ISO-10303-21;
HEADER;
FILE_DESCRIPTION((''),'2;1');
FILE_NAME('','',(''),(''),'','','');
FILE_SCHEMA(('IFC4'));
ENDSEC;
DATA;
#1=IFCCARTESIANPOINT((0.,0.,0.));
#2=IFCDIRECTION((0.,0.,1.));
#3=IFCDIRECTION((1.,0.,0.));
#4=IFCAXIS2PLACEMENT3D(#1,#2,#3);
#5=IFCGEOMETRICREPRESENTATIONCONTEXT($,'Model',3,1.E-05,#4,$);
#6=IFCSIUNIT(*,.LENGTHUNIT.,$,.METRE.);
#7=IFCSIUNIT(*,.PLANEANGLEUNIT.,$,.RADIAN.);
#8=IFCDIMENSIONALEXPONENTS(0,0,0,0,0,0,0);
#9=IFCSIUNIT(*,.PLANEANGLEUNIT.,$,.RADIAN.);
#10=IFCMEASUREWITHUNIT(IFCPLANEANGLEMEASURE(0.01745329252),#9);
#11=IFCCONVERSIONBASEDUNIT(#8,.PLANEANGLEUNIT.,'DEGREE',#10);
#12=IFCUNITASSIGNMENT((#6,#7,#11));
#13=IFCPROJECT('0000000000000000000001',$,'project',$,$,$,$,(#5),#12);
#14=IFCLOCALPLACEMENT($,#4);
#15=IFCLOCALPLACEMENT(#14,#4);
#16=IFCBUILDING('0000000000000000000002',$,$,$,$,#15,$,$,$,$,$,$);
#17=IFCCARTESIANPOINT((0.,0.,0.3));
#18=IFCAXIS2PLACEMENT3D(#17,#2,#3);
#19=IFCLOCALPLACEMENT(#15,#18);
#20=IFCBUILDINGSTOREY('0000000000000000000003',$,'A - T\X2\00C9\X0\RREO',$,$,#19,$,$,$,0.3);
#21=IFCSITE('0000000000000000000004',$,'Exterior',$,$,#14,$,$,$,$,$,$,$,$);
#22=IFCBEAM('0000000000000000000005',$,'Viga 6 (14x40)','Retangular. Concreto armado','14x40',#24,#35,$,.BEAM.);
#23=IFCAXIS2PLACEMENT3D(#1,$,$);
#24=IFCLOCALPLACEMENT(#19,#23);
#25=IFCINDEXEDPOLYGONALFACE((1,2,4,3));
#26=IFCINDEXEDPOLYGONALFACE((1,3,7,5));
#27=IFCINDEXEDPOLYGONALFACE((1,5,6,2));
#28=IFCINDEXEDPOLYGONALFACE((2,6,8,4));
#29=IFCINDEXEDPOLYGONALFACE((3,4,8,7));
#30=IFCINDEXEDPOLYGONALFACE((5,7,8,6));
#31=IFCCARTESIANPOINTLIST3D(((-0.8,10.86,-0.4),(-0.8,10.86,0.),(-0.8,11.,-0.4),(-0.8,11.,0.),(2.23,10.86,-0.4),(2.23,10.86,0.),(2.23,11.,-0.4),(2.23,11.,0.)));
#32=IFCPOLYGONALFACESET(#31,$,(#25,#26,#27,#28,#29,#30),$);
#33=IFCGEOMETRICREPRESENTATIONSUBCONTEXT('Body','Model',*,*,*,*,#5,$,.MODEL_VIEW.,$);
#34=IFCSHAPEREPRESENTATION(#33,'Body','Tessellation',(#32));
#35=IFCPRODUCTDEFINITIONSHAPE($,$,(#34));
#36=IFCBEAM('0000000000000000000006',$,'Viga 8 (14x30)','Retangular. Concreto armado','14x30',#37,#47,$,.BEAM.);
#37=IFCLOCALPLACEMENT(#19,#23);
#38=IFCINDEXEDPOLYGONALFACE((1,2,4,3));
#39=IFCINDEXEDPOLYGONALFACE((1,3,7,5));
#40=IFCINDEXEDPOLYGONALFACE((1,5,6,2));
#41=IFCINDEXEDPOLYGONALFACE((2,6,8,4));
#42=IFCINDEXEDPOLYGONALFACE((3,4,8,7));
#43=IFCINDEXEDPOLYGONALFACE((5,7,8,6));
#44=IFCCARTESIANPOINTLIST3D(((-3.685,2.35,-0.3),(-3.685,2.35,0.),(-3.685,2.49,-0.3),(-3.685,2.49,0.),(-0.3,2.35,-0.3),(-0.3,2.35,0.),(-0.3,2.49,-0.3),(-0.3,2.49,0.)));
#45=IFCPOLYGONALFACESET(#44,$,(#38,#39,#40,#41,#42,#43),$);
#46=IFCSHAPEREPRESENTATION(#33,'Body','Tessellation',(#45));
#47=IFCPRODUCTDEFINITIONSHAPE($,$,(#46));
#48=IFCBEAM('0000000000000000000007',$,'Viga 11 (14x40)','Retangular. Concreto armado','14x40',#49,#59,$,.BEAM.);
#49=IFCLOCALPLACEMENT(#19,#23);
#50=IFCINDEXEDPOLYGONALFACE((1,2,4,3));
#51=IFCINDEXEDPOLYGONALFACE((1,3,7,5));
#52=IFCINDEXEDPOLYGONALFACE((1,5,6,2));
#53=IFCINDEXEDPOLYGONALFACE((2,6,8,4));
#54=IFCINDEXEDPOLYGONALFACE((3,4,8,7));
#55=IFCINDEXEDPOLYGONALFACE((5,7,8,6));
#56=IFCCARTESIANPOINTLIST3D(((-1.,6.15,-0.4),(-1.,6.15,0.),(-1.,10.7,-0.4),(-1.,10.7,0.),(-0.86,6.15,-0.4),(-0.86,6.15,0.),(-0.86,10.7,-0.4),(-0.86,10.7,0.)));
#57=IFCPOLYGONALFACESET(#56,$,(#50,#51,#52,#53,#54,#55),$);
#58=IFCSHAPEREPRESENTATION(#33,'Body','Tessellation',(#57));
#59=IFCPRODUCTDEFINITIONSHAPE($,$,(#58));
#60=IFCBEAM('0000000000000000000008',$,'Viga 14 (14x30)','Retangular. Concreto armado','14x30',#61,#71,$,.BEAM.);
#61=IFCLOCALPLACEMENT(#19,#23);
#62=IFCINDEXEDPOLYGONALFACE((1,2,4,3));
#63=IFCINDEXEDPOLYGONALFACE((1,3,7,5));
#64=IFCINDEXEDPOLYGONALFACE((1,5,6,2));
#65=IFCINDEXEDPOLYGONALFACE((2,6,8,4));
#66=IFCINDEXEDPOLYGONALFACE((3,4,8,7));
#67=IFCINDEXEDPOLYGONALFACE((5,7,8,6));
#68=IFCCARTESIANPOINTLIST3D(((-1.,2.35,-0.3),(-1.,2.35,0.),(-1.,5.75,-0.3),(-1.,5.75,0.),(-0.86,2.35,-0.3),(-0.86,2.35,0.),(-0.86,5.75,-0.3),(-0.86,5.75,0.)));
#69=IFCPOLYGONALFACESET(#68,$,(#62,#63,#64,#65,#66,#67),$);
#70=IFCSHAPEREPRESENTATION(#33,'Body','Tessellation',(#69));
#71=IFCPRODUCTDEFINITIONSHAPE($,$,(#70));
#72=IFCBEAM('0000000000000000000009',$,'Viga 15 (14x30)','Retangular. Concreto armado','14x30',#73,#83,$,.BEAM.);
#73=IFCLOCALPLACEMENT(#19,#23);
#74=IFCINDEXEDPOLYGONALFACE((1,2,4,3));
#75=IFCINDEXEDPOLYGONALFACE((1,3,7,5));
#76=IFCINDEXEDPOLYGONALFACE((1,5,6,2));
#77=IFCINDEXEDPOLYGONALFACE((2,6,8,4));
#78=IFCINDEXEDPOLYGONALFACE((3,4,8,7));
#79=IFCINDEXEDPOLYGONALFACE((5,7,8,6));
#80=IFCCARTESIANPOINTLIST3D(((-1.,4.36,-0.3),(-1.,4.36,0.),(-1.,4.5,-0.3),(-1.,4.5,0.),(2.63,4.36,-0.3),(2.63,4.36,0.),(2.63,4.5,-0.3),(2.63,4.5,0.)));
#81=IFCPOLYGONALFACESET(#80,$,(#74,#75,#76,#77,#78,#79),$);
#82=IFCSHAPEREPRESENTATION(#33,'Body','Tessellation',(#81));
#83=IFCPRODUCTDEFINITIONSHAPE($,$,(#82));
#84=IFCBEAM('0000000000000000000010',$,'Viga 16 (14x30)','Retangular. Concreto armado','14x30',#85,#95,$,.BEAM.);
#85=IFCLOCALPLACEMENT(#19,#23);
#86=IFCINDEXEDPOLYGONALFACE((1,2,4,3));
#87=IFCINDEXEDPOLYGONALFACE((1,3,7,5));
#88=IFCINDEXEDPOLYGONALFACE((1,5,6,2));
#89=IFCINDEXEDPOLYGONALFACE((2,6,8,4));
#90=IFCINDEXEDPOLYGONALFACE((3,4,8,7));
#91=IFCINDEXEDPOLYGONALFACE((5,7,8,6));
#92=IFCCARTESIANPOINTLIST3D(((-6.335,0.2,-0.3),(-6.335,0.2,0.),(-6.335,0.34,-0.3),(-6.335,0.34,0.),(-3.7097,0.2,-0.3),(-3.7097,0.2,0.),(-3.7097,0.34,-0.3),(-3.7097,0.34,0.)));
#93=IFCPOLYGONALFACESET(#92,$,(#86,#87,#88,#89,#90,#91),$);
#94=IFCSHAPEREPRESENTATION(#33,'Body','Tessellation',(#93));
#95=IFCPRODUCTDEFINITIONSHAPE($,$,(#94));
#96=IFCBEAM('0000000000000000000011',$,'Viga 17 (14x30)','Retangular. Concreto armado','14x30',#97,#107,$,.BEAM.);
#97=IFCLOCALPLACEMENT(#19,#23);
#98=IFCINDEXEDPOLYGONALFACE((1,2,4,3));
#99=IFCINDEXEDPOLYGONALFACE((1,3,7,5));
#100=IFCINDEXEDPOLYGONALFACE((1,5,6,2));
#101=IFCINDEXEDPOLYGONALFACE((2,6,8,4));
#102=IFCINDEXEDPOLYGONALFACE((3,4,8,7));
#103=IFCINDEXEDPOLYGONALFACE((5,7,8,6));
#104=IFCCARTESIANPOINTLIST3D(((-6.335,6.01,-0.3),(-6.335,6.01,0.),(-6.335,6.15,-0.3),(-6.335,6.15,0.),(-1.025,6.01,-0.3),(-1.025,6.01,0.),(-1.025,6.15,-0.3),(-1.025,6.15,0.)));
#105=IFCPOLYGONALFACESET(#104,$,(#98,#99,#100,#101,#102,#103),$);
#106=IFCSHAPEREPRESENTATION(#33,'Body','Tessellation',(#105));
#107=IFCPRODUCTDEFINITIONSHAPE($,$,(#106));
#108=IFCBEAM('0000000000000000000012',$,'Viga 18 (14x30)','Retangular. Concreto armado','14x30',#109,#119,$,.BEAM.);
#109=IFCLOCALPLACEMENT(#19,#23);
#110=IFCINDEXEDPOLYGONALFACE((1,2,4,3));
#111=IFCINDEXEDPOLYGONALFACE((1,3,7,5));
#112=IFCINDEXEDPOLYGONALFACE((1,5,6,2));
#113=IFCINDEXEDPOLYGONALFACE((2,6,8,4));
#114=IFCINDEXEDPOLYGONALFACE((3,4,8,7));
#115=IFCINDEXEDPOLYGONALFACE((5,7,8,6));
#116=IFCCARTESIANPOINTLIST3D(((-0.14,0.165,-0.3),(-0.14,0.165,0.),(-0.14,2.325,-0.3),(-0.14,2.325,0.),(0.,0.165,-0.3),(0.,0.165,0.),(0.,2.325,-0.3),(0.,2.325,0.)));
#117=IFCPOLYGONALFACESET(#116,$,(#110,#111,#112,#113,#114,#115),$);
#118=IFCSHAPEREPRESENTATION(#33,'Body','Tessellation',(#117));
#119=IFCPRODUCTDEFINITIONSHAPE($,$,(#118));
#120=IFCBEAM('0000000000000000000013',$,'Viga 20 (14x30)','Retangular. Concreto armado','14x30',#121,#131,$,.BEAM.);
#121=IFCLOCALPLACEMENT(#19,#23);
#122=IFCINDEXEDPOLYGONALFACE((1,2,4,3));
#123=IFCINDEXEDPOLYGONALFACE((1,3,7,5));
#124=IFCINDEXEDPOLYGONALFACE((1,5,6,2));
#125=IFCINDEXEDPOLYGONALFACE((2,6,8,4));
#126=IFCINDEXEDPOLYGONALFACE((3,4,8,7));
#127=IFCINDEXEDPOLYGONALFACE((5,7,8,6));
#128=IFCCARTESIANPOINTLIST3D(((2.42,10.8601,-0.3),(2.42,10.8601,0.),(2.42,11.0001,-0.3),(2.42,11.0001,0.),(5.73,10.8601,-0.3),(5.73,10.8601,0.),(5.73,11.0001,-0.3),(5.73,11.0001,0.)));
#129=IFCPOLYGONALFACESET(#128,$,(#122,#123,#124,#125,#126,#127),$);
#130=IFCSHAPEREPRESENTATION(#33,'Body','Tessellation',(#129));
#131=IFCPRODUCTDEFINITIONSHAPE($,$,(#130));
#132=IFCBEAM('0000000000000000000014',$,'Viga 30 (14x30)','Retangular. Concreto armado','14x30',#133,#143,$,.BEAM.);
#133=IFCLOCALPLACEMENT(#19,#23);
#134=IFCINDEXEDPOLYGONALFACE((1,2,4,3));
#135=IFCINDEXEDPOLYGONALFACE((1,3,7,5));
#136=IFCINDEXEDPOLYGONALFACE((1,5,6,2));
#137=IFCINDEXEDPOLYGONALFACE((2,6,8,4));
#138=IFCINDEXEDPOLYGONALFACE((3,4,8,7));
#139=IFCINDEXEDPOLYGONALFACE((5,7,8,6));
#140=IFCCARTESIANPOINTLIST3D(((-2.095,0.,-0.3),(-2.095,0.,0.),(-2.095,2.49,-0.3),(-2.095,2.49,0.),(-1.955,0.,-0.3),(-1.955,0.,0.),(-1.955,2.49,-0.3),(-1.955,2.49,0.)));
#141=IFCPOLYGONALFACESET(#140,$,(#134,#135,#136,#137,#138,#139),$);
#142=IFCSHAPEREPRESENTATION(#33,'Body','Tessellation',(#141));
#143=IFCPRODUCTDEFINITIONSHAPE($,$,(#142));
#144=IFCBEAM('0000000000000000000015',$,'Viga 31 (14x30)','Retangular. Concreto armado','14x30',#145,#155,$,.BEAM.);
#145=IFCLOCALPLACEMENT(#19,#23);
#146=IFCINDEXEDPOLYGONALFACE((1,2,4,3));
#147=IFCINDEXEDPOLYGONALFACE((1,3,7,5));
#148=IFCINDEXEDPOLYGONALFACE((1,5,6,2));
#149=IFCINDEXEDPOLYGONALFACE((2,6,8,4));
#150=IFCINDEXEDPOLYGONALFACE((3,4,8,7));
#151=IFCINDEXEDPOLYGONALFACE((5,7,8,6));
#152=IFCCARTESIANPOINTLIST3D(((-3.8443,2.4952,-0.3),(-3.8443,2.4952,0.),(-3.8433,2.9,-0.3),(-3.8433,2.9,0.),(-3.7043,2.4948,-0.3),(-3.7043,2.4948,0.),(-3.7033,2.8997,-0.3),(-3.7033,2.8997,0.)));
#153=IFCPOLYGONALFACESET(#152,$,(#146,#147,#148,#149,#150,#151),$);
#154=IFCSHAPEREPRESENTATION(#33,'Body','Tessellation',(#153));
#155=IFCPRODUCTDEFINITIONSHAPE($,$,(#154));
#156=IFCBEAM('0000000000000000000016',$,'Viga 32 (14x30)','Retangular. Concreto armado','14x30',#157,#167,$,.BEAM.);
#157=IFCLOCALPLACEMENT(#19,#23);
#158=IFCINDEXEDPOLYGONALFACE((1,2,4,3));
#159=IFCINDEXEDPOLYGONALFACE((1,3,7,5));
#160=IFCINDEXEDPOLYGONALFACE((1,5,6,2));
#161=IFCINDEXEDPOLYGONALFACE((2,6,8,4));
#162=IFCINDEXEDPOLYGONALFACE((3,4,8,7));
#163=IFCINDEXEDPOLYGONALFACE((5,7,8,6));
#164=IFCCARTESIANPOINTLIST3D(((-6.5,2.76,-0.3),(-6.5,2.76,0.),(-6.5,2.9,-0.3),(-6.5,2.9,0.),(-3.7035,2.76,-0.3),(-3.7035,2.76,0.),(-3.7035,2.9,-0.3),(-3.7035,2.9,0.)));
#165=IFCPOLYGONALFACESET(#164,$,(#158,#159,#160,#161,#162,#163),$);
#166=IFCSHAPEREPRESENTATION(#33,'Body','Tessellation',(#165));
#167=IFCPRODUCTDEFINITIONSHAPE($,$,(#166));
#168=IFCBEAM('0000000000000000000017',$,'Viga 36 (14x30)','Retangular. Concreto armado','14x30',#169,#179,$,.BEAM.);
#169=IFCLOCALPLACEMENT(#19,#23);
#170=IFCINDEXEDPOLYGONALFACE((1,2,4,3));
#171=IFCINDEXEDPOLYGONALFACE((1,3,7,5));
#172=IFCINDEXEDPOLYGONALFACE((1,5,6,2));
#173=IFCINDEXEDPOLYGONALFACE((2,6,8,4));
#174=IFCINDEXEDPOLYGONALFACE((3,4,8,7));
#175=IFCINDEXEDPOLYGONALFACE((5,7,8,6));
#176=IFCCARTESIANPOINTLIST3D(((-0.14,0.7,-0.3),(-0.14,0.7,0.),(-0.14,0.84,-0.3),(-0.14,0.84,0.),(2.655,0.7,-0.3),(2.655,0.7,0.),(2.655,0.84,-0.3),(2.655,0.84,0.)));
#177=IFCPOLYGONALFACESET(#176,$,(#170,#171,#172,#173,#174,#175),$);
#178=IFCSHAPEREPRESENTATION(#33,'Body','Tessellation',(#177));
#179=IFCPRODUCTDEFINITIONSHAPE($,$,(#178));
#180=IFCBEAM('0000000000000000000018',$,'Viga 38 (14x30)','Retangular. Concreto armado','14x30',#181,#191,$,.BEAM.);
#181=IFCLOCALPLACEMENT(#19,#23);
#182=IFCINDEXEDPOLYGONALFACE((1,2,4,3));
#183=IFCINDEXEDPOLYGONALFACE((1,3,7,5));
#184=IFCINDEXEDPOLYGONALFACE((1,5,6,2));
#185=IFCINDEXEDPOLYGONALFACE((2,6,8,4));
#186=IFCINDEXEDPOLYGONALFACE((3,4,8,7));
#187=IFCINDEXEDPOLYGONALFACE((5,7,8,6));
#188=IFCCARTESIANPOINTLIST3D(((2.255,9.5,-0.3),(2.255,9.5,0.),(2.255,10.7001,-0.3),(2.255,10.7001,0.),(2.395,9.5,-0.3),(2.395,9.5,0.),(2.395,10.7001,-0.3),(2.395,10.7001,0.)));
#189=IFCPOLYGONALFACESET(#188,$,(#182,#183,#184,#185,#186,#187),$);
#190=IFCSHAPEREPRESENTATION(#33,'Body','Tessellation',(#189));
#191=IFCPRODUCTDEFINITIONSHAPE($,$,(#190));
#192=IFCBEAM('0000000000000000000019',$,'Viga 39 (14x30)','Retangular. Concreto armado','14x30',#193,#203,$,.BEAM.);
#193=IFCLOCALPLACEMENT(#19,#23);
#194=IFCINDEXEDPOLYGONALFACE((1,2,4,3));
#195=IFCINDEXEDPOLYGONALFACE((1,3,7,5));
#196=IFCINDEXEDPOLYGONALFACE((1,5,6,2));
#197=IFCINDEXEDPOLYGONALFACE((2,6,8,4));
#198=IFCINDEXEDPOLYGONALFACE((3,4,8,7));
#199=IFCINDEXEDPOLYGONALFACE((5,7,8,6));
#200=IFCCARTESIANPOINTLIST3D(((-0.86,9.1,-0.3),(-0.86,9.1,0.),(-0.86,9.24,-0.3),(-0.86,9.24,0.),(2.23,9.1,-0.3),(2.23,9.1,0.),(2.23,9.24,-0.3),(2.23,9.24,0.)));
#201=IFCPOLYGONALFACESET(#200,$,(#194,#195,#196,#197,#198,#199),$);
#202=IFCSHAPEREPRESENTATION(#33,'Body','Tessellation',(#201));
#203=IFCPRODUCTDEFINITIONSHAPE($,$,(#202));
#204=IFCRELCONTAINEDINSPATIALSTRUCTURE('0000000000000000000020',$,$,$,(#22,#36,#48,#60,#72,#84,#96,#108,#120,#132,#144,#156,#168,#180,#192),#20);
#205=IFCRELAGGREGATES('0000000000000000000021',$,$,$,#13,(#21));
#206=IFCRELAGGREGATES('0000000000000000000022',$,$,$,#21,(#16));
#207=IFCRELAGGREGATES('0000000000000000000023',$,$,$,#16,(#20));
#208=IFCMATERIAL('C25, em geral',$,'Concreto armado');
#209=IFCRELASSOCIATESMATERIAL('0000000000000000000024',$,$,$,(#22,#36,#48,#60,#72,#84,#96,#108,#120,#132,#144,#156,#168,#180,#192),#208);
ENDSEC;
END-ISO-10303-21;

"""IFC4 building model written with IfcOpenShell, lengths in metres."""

from ifc_helpers import new_model, entity, si_unit, converted_unit, frame, frame_2d, origin_with_axes, place, context, subcontext, project, spatial, rectangle, extrude, material, element, save


model = new_model("IFC4")

# Units and contexts
model_context = context("Model", 3, precision=1e-05, world=origin_with_axes())
body_context = subcontext(model_context, "Body", "Model", "MODEL_VIEW")
ifc_project = project(units=[si_unit("LENGTHUNIT", "METRE"), si_unit("PLANEANGLEUNIT", "RADIAN"), converted_unit("PLANEANGLEUNIT", "DEGREE", entity("IfcPlaneAngleMeasure", 0.01745329252), si_unit("PLANEANGLEUNIT", "RADIAN"), dimensions=[0, 0, 0, 0, 0, 0, 0])], contexts=[model_context])

# Site, building, storey
site_placement = place(None, origin_with_axes())
site = spatial("IfcSite", under=ifc_project, at=site_placement, Name="Exterior")
building_placement = place(site_placement, origin_with_axes())
building = spatial("IfcBuilding", under=site, at=building_placement)
storey_placement = place(building_placement, frame((0.0, 0.0, 0.3), z_axis=(0.0, 0.0, 1.0), x_axis=(1.0, 0.0, 0.0)))
storey = spatial("IfcBuildingStorey", under=building, at=storey_placement, Name="A - TÉRREO", Elevation=0.3)

# Shared definitions
ifc_material = material(Name="C25, em geral", Category="Concreto armado")

# Beams
beam_1_placement = place(storey_placement, frame((-0.8, 10.93, 0.0), z_axis=(1.0, 0.0, 0.0), x_axis=(0.0, 1.0, 0.0)))
element("IfcBeam", 1, at=beam_1_placement, inside=storey, material=ifc_material, Name="Viga 6 (14x40)", Description="Retangular. Concreto armado", ObjectType="14x40", PredefinedType="BEAM", context=body_context, shape_type="SweptSolid", body=[
    extrude(rectangle(XDim=0.14, YDim=0.4, at=frame_2d((0.0, -0.2), x_axis=(1.0, 0.0))), origin_with_axes(), (0.0, 0.0, 1.0), 3.03),
])
beam_2_placement = place(storey_placement, frame((-0.3, 2.42, 0.0), z_axis=(-1.0, 0.0, 0.0), x_axis=(0.0, -1.0, 0.0)))
element("IfcBeam", 2, at=beam_2_placement, inside=storey, material=ifc_material, Name="Viga 8 (14x30)", Description="Retangular. Concreto armado", ObjectType="14x30", PredefinedType="BEAM", context=body_context, shape_type="SweptSolid", body=[
    extrude(rectangle(XDim=0.14, YDim=0.3, at=frame_2d((0.0, -0.15), x_axis=(1.0, 0.0))), origin_with_axes(), (0.0, 0.0, 1.0), 3.385),
])
beam_3_placement = place(storey_placement, frame((-0.93, 10.7, 0.0), z_axis=(0.0, -1.0, 0.0), x_axis=(1.0, 0.0, 0.0)))
element("IfcBeam", 3, at=beam_3_placement, inside=storey, material=ifc_material, Name="Viga 11 (14x40)", Description="Retangular. Concreto armado", ObjectType="14x40", PredefinedType="BEAM", context=body_context, shape_type="SweptSolid", body=[
    extrude(rectangle(XDim=0.14, YDim=0.4, at=frame_2d((0.0, -0.2), x_axis=(1.0, 0.0))), origin_with_axes(), (0.0, 0.0, 1.0), 4.55),
])
beam_4_placement = place(storey_placement, frame((-0.93, 2.35, 0.0), z_axis=(0.0, 1.0, 0.0), x_axis=(-1.0, 0.0, 0.0)))
element("IfcBeam", 4, at=beam_4_placement, inside=storey, material=ifc_material, Name="Viga 14 (14x30)", Description="Retangular. Concreto armado", ObjectType="14x30", PredefinedType="BEAM", context=body_context, shape_type="SweptSolid", body=[
    extrude(rectangle(XDim=0.14, YDim=0.3, at=frame_2d((0.0, -0.15), x_axis=(1.0, 0.0))), origin_with_axes(), (0.0, 0.0, 1.0), 3.4),
])
beam_5_placement = place(storey_placement, frame((2.63, 4.43, 0.0), z_axis=(-1.0, 0.0, 0.0), x_axis=(0.0, -1.0, 0.0)))
element("IfcBeam", 5, at=beam_5_placement, inside=storey, material=ifc_material, Name="Viga 15 (14x30)", Description="Retangular. Concreto armado", ObjectType="14x30", PredefinedType="BEAM", context=body_context, shape_type="SweptSolid", body=[
    extrude(rectangle(XDim=0.14, YDim=0.3, at=frame_2d((0.0, -0.15), x_axis=(1.0, 0.0))), origin_with_axes(), (0.0, 0.0, 1.0), 3.63),
])
beam_6_placement = place(storey_placement, frame((-6.335, 0.27, 0.0), z_axis=(1.0, 0.0, 0.0), x_axis=(0.0, 1.0, 0.0)))
element("IfcBeam", 6, at=beam_6_placement, inside=storey, material=ifc_material, Name="Viga 16 (14x30)", Description="Retangular. Concreto armado", ObjectType="14x30", PredefinedType="BEAM", context=body_context, shape_type="SweptSolid", body=[
    extrude(rectangle(XDim=0.14, YDim=0.3, at=frame_2d((0.0, -0.15), x_axis=(1.0, 0.0))), origin_with_axes(), (0.0, 0.0, 1.0), 2.6253),
])
beam_7_placement = place(storey_placement, frame((-6.335, 6.08, 0.0), z_axis=(1.0, 0.0, 0.0), x_axis=(0.0, 1.0, 0.0)))
element("IfcBeam", 7, at=beam_7_placement, inside=storey, material=ifc_material, Name="Viga 17 (14x30)", Description="Retangular. Concreto armado", ObjectType="14x30", PredefinedType="BEAM", context=body_context, shape_type="SweptSolid", body=[
    extrude(rectangle(XDim=0.14, YDim=0.3, at=frame_2d((0.0, -0.15), x_axis=(1.0, 0.0))), origin_with_axes(), (0.0, 0.0, 1.0), 5.31),
])
beam_8_placement = place(storey_placement, frame((-0.07, 0.165, 0.0), z_axis=(0.0, 1.0, 0.0), x_axis=(-1.0, 0.0, 0.0)))
element("IfcBeam", 8, at=beam_8_placement, inside=storey, material=ifc_material, Name="Viga 18 (14x30)", Description="Retangular. Concreto armado", ObjectType="14x30", PredefinedType="BEAM", context=body_context, shape_type="SweptSolid", body=[
    extrude(rectangle(XDim=0.14, YDim=0.3, at=frame_2d((0.0, -0.15), x_axis=(1.0, 0.0))), origin_with_axes(), (0.0, 0.0, 1.0), 2.16),
])
beam_9_placement = place(storey_placement, frame((2.42, 10.9301, 0.0), z_axis=(1.0, 0.0, 0.0), x_axis=(0.0, 1.0, 0.0)))
element("IfcBeam", 9, at=beam_9_placement, inside=storey, material=ifc_material, Name="Viga 20 (14x30)", Description="Retangular. Concreto armado", ObjectType="14x30", PredefinedType="BEAM", context=body_context, shape_type="SweptSolid", body=[
    extrude(rectangle(XDim=0.14, YDim=0.3, at=frame_2d((0.0, -0.15), x_axis=(1.0, 0.0))), origin_with_axes(), (0.0, 0.0, 1.0), 3.31),
])
beam_10_placement = place(storey_placement, frame((-2.025, 0.0, 0.0), z_axis=(0.0, 1.0, 0.0), x_axis=(-1.0, 0.0, 0.0)))
element("IfcBeam", 10, at=beam_10_placement, inside=storey, material=ifc_material, Name="Viga 30 (14x30)", Description="Retangular. Concreto armado", ObjectType="14x30", PredefinedType="BEAM", context=body_context, shape_type="SweptSolid", body=[
    extrude(rectangle(XDim=0.14, YDim=0.3, at=frame_2d((0.0, -0.15), x_axis=(1.0, 0.0))), origin_with_axes(), (0.0, 0.0, 1.0), 2.49),
])
beam_11_placement = place(storey_placement, frame((-3.7743, 2.495, 0.0), z_axis=(0.002427, 0.999997, 0.0), x_axis=(-0.999997, 0.002427, 0.0)))
element("IfcBeam", 11, at=beam_11_placement, inside=storey, material=ifc_material, Name="Viga 31 (14x30)", Description="Retangular. Concreto armado", ObjectType="14x30", PredefinedType="BEAM", context=body_context, shape_type="SweptSolid", body=[
    extrude(rectangle(XDim=0.14, YDim=0.3, at=frame_2d((0.0, -0.15), x_axis=(1.0, 0.0))), origin_with_axes(), (0.0, 0.0, 1.0), 0.4048),
])
beam_12_placement = place(storey_placement, frame((-3.7035, 2.83, 0.0), z_axis=(-1.0, 0.0, 0.0), x_axis=(0.0, -1.0, 0.0)))
element("IfcBeam", 12, at=beam_12_placement, inside=storey, material=ifc_material, Name="Viga 32 (14x30)", Description="Retangular. Concreto armado", ObjectType="14x30", PredefinedType="BEAM", context=body_context, shape_type="SweptSolid", body=[
    extrude(rectangle(XDim=0.14, YDim=0.3, at=frame_2d((0.0, -0.15), x_axis=(1.0, 0.0))), origin_with_axes(), (0.0, 0.0, 1.0), 2.7965),
])
beam_13_placement = place(storey_placement, frame((2.655, 0.77, 0.0), z_axis=(-1.0, 0.0, 0.0), x_axis=(0.0, -1.0, 0.0)))
element("IfcBeam", 13, at=beam_13_placement, inside=storey, material=ifc_material, Name="Viga 36 (14x30)", Description="Retangular. Concreto armado", ObjectType="14x30", PredefinedType="BEAM", context=body_context, shape_type="SweptSolid", body=[
    extrude(rectangle(XDim=0.14, YDim=0.3, at=frame_2d((0.0, -0.15), x_axis=(1.0, 0.0))), origin_with_axes(), (0.0, 0.0, 1.0), 2.795),
])
beam_14_placement = place(storey_placement, frame((2.325, 10.7001, 0.0), z_axis=(0.0, -1.0, 0.0), x_axis=(1.0, 0.0, 0.0)))
element("IfcBeam", 14, at=beam_14_placement, inside=storey, material=ifc_material, Name="Viga 38 (14x30)", Description="Retangular. Concreto armado", ObjectType="14x30", PredefinedType="BEAM", context=body_context, shape_type="SweptSolid", body=[
    extrude(rectangle(XDim=0.14, YDim=0.3, at=frame_2d((0.0, -0.15), x_axis=(1.0, 0.0))), origin_with_axes(), (0.0, 0.0, 1.0), 1.2001),
])
beam_15_placement = place(storey_placement, frame((2.23, 9.17, 0.0), z_axis=(-1.0, 0.0, 0.0), x_axis=(0.0, -1.0, 0.0)))
element("IfcBeam", 15, at=beam_15_placement, inside=storey, material=ifc_material, Name="Viga 39 (14x30)", Description="Retangular. Concreto armado", ObjectType="14x30", PredefinedType="BEAM", context=body_context, shape_type="SweptSolid", body=[
    extrude(rectangle(XDim=0.14, YDim=0.3, at=frame_2d((0.0, -0.15), x_axis=(1.0, 0.0))), origin_with_axes(), (0.0, 0.0, 1.0), 3.09),
])

save(model, "model.ifc")
